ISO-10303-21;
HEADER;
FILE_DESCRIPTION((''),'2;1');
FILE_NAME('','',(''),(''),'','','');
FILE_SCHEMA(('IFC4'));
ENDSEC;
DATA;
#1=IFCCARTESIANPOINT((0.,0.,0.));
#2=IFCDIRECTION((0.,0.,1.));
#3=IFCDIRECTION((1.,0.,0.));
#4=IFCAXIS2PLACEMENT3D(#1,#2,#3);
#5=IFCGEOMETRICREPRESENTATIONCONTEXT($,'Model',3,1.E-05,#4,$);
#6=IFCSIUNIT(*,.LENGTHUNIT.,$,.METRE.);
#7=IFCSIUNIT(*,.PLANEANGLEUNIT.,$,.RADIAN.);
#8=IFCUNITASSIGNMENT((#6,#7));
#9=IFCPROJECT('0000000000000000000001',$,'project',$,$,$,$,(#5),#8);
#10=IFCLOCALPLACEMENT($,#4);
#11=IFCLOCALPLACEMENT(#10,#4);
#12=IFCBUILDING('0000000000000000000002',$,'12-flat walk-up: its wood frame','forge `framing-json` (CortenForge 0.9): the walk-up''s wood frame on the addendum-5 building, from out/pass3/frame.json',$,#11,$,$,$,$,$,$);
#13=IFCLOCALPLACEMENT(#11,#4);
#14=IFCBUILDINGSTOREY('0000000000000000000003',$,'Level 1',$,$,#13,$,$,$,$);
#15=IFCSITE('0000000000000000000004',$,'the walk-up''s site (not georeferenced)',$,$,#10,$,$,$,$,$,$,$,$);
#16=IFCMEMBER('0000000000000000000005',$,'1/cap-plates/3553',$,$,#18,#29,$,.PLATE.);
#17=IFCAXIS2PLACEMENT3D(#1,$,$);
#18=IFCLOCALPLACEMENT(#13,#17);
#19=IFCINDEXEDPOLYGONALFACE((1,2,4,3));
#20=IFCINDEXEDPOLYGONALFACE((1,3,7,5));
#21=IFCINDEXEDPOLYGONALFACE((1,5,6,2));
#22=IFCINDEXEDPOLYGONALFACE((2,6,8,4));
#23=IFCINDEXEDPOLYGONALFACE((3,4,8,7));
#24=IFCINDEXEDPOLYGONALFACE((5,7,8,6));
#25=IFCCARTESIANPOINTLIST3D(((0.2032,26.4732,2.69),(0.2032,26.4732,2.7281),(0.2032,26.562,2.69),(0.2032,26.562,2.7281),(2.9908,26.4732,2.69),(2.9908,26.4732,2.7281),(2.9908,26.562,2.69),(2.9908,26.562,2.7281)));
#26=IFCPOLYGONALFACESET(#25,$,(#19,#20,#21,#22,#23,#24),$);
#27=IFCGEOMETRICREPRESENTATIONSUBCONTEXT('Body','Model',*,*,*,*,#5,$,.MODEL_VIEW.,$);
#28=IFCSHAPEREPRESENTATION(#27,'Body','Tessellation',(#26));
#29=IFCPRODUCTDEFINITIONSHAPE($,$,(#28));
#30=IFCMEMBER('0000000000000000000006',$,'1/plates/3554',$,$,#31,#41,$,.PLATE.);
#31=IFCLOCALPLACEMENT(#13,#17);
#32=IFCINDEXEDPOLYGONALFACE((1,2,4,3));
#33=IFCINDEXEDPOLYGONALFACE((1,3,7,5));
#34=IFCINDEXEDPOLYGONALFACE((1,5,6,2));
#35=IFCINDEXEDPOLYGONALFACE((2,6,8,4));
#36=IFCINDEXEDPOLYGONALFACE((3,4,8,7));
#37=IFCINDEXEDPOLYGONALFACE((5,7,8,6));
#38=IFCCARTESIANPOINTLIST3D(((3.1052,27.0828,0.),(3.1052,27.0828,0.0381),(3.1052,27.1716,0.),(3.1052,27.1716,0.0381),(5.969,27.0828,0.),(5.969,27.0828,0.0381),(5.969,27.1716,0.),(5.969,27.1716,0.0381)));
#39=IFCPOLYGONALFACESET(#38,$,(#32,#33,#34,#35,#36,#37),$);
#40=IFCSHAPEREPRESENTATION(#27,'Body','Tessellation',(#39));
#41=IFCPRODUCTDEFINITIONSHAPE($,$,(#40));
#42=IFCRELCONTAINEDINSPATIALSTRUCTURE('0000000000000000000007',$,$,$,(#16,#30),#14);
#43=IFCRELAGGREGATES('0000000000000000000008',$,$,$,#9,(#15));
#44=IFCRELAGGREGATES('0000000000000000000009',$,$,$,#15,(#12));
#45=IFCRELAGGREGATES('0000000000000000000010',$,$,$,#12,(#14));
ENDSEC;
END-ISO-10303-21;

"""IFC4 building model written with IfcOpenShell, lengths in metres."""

from ifc_helpers import new_model, si_unit, frame, frame_2d, origin, origin_with_axes, place, context, subcontext, project, spatial, rectangle, extrude, element, save


model = new_model("IFC4")

# Units and contexts
model_context = context("Model", 3, precision=1e-05, world=origin_with_axes())
body_context = subcontext(model_context, "Body", "Model", "MODEL_VIEW")
ifc_project = project(units=[si_unit("LENGTHUNIT", "METRE"), si_unit("PLANEANGLEUNIT", "RADIAN")], contexts=[model_context])

# Site, building, storey
site_placement = place(None, origin_with_axes())
site = spatial("IfcSite", under=ifc_project, at=site_placement, Name="the walk-up's site (not georeferenced)")
building_placement = place(site_placement, origin_with_axes())
building = spatial("IfcBuilding", under=site, at=building_placement, Name="12-flat walk-up: its wood frame", Description="forge `framing-json` (CortenForge 0.9): the walk-up's wood frame on the addendum-5 building, from out/pass3/frame.json")
storey_placement = place(building_placement, origin_with_axes())
storey = spatial("IfcBuildingStorey", under=building, at=storey_placement, Name="Level 1")

# Members
member_1_placement = place(storey_placement, frame((0.2032, 26.4732, 2.69), z_axis=(0.0, 0.0, 1.0), x_axis=(1.0, 0.0, 0.0)))
element("IfcMember", 1, at=member_1_placement, inside=storey, Name="1/cap-plates/3553", PredefinedType="PLATE", context=body_context, shape_type="SweptSolid", body=[
    extrude(rectangle(XDim=2.7877, YDim=0.0889, at=frame_2d((1.3938, 0.0444))), origin(), (0.0, 0.0, 1.0), 0.0381),
])
member_2_placement = place(storey_placement, frame((3.1052, 27.0828, 0.0), z_axis=(0.0, 0.0, 1.0), x_axis=(1.0, 0.0, 0.0)))
element("IfcMember", 2, at=member_2_placement, inside=storey, Name="1/plates/3554", PredefinedType="PLATE", context=body_context, shape_type="SweptSolid", body=[
    extrude(rectangle(XDim=2.8639, YDim=0.0889, at=frame_2d((1.4319, 0.0444))), origin(), (0.0, 0.0, 1.0), 0.0381),
])

save(model, "model.ifc")
